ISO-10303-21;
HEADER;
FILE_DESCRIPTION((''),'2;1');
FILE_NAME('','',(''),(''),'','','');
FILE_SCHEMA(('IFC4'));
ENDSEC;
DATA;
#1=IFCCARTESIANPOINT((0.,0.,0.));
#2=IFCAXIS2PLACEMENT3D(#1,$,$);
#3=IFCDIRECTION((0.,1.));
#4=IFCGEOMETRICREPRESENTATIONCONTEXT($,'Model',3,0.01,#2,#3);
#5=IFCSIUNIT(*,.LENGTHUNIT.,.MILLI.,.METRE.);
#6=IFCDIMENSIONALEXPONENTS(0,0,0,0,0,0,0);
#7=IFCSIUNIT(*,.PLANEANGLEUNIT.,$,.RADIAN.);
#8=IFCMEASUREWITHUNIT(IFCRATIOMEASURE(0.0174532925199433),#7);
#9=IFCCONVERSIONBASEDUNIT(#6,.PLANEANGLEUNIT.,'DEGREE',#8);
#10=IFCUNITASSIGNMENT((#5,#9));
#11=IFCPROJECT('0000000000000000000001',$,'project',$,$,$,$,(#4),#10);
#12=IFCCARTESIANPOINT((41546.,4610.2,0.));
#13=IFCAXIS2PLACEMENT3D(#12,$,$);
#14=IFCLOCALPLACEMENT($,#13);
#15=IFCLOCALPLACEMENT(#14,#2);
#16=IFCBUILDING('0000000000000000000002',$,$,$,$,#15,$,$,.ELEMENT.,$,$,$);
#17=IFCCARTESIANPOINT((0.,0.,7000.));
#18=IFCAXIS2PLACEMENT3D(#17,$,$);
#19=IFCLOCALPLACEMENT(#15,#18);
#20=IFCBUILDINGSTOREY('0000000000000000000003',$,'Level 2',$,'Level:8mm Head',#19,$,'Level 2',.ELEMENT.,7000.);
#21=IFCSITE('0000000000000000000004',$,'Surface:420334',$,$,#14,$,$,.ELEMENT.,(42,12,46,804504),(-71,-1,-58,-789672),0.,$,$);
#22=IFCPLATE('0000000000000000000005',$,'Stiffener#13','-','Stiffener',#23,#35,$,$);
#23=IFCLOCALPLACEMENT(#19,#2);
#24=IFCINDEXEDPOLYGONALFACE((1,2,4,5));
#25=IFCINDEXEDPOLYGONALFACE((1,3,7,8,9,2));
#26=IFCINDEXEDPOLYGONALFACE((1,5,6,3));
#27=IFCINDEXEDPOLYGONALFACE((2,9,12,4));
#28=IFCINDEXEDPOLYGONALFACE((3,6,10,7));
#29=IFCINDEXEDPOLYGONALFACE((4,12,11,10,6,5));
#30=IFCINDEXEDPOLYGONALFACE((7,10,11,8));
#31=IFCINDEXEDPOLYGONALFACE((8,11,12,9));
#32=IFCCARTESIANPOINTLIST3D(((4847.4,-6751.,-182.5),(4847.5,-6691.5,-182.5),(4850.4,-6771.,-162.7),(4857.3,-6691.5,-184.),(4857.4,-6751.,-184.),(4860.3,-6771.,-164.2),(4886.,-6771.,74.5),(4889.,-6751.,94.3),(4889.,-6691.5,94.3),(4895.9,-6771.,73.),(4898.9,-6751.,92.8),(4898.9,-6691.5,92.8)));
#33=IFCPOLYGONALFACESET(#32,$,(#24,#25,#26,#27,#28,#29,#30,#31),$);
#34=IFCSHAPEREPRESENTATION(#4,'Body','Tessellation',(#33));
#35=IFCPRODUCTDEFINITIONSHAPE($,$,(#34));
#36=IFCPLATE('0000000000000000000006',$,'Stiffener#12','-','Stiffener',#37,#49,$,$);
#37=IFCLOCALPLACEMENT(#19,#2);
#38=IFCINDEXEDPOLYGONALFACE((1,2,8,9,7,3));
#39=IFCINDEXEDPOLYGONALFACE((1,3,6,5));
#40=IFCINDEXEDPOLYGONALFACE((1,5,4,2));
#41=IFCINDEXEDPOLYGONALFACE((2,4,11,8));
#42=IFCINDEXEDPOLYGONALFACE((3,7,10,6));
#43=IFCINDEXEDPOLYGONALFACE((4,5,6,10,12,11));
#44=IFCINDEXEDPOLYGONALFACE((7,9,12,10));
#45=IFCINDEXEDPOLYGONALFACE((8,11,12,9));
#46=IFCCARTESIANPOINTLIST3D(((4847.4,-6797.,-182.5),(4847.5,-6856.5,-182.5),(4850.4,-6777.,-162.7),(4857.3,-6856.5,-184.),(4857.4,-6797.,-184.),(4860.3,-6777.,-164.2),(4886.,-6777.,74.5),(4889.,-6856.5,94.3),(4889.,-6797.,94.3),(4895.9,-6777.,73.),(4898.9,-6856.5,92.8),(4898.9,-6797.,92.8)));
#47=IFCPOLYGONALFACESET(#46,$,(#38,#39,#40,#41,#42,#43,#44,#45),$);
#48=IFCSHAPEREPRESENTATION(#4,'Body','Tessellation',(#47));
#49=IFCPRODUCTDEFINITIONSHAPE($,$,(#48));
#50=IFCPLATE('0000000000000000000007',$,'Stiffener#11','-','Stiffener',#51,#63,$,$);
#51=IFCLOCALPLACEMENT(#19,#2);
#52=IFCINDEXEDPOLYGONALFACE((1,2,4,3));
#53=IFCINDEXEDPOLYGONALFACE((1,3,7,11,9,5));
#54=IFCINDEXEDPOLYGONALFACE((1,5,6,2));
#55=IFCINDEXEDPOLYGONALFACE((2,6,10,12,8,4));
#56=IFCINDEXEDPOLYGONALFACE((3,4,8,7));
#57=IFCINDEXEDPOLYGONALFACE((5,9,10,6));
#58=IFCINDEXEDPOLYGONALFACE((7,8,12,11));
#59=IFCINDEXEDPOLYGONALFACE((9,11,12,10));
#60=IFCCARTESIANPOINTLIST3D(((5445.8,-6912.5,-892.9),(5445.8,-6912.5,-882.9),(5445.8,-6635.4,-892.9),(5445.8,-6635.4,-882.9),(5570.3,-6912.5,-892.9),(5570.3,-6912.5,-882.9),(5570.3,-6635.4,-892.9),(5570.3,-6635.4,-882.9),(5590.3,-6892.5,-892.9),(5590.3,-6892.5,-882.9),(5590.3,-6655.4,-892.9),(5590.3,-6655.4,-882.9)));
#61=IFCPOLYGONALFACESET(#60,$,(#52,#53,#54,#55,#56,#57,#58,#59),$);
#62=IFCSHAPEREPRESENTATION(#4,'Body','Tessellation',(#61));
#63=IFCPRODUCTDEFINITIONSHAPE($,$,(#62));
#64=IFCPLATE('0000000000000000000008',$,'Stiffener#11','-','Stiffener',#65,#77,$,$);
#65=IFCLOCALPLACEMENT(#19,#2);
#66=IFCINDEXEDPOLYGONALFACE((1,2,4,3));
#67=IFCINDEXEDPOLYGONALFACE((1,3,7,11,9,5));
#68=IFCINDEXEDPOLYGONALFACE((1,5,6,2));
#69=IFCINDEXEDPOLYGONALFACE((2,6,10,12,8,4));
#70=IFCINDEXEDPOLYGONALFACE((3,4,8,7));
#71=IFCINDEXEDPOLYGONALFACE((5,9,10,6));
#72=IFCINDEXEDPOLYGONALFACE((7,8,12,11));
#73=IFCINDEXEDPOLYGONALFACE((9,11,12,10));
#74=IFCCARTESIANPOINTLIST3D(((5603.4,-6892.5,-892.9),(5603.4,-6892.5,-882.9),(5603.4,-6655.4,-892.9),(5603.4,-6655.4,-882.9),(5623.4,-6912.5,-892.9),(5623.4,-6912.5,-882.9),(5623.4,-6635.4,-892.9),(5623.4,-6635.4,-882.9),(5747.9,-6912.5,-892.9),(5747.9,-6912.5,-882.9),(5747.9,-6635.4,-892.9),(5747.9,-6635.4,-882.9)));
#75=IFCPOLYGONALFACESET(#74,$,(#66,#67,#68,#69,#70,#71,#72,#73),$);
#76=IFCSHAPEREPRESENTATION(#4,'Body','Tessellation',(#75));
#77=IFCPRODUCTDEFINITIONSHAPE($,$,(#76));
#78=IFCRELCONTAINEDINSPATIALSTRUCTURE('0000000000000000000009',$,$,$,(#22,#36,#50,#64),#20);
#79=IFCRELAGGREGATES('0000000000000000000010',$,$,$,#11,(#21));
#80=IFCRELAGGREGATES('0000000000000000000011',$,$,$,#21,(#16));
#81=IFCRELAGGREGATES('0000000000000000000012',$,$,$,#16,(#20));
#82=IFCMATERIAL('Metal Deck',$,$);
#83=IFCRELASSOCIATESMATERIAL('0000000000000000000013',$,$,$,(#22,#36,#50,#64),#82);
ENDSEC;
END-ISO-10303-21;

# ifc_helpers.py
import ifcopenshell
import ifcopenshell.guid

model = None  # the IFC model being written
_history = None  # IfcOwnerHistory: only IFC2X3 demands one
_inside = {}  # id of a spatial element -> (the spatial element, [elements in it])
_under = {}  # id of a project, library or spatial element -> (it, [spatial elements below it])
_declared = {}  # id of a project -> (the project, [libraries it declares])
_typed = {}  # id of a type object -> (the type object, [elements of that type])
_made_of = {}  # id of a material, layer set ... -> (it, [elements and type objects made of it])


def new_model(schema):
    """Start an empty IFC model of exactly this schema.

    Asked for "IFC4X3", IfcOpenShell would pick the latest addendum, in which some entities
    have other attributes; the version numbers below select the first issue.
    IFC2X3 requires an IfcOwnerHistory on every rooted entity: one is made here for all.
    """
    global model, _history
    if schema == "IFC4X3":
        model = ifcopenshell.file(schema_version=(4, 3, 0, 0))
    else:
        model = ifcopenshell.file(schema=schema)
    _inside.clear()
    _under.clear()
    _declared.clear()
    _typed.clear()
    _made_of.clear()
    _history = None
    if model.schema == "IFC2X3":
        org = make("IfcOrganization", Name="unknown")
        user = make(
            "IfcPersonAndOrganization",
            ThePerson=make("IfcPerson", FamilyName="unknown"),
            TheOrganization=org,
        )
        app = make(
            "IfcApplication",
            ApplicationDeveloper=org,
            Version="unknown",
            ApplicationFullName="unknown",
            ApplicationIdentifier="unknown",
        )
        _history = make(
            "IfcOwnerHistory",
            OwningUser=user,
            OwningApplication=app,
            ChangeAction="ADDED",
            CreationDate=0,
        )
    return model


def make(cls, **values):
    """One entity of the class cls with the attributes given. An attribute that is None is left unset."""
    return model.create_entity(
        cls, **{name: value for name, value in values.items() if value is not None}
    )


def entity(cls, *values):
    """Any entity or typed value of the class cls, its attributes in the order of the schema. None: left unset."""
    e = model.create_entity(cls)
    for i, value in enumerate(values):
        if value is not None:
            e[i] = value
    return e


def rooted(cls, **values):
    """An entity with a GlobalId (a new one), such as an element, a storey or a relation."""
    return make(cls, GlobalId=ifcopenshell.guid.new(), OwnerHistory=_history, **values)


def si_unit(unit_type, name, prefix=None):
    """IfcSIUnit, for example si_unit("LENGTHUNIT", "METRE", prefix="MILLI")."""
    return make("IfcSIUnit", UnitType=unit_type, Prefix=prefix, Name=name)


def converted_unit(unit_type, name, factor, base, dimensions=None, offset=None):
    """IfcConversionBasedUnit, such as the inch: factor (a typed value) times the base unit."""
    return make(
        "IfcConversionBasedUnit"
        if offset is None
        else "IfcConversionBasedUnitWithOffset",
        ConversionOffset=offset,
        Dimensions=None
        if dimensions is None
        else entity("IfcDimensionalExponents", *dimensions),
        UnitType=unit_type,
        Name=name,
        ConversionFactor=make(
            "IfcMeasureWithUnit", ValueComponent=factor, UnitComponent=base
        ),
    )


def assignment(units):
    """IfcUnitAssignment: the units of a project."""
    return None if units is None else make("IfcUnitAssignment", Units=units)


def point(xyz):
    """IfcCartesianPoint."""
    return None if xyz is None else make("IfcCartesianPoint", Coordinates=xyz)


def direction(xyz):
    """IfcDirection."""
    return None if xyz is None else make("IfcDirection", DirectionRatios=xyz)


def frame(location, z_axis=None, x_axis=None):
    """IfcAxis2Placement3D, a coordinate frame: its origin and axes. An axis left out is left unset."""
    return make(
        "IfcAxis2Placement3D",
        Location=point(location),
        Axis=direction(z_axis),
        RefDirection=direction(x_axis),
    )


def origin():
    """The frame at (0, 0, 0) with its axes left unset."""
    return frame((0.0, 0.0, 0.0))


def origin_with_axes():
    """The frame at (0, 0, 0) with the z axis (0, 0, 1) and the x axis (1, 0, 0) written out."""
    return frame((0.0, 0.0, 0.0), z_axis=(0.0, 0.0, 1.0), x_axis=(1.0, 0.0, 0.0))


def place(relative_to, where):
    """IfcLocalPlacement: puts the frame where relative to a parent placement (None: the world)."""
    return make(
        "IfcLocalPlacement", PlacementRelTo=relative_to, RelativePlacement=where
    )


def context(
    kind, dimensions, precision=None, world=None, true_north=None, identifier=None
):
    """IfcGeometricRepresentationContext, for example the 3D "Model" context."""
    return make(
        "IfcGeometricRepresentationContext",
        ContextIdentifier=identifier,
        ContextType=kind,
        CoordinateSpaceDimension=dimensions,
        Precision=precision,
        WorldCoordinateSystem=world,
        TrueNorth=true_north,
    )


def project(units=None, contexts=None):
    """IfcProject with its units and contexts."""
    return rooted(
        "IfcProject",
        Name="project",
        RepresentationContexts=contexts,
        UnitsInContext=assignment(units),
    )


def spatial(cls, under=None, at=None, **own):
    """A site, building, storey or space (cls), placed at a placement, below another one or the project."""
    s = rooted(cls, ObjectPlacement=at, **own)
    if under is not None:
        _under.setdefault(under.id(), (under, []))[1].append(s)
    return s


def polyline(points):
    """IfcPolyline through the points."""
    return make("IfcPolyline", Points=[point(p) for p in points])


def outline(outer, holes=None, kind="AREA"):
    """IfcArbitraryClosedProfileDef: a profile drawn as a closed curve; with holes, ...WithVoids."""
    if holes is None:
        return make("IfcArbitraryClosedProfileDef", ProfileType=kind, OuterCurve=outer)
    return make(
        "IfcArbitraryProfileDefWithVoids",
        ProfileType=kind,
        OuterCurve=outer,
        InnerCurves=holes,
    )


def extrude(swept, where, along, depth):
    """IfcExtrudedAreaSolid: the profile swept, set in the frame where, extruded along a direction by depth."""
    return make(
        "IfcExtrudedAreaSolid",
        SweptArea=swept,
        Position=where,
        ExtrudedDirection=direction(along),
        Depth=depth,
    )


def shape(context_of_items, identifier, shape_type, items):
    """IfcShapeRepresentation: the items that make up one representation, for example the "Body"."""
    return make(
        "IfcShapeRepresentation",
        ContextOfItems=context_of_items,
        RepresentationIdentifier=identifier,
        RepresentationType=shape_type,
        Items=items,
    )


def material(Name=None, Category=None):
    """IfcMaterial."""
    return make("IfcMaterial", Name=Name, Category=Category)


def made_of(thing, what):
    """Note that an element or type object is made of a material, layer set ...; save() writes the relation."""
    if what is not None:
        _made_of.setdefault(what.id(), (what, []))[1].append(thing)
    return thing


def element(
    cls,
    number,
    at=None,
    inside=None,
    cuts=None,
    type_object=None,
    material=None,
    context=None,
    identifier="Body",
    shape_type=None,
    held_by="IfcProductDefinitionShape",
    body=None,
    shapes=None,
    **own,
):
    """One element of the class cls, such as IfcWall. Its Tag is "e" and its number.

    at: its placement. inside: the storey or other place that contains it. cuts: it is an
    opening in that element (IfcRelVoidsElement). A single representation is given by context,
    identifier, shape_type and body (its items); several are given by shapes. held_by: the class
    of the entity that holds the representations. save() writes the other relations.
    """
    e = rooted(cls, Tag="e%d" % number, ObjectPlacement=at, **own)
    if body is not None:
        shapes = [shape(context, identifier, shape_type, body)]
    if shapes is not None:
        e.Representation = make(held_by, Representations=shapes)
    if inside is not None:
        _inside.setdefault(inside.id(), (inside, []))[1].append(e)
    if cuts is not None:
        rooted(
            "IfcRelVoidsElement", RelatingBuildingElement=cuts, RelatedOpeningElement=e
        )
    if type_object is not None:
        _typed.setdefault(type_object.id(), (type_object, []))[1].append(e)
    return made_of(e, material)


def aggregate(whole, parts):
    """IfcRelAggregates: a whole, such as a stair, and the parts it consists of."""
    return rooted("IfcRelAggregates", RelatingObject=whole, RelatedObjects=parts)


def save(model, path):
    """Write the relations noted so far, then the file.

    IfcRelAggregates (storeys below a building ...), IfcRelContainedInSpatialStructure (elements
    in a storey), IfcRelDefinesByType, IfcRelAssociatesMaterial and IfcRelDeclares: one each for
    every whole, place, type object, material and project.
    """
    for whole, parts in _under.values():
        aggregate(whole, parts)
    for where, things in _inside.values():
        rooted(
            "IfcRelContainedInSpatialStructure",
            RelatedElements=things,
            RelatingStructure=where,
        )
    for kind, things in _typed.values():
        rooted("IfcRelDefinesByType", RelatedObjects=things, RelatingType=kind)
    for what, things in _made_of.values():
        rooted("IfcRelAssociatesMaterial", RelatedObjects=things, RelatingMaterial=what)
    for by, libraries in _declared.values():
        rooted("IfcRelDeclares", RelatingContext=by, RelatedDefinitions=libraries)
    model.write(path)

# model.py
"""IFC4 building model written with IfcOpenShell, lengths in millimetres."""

from ifc_helpers import new_model, entity, si_unit, converted_unit, direction, frame, origin, origin_with_axes, place, context, project, spatial, polyline, outline, extrude, material, element, save


model = new_model("IFC4")

# Units and contexts
model_context = context("Model", 3, precision=0.01, world=origin(), true_north=direction((0.0, 1.0)))
ifc_project = project(units=[si_unit("LENGTHUNIT", "METRE", prefix="MILLI"), converted_unit("PLANEANGLEUNIT", "DEGREE", entity("IfcRatioMeasure", 0.0174532925199433), si_unit("PLANEANGLEUNIT", "RADIAN"), dimensions=[0, 0, 0, 0, 0, 0, 0])], contexts=[model_context])

# Site, building, storey
site_placement = place(None, frame((41546.0, 4610.2, 0.0)))
site = spatial("IfcSite", under=ifc_project, at=site_placement, Name="Surface:420334", CompositionType="ELEMENT", RefLatitude=(42, 12, 46, 804504), RefLongitude=(-71, -1, -58, -789672), RefElevation=0.0)
building_placement = place(site_placement, origin())
building = spatial("IfcBuilding", under=site, at=building_placement, CompositionType="ELEMENT")
storey_placement = place(building_placement, frame((0.0, 0.0, 7000.0)))
storey = spatial("IfcBuildingStorey", under=building, at=storey_placement, Name="Level 2", ObjectType="Level:8mm Head", LongName="Level 2", CompositionType="ELEMENT", Elevation=7000.0)

# Plates, openings
ifc_material = material(Name="Metal Deck")
plate_1_placement = place(storey_placement, frame((4857.3, -6691.5, -184.0), z_axis=(-0.988936, 0.0, 0.14834), x_axis=(0.0, -1.0, 0.0)))
plate_1 = element("IfcPlate", 1, at=plate_1_placement, inside=storey, material=ifc_material, Name="Stiffener#13", Description="-", ObjectType="Stiffener", context=model_context, shape_type="SweptSolid", body=[
    extrude(outline(polyline([(0.0, 0.0), (79.5, 0.0), (79.5, 279.8), (0.0, 279.8), (0.0, 0.0)])), origin_with_axes(), (0.0, 0.0, 1.0), 10.0),
])
opening_1_placement = place(plate_1_placement, frame((0.0, 0.0, 0.0), z_axis=(0.0, 0.0, 1.0), x_axis=(1.0, 0.0, 0.0)))
element("IfcOpeningElement", 2, at=opening_1_placement, cuts=plate_1, ObjectType="Opening", context=model_context, shape_type="SweptSolid", body=[
    extrude(outline(polyline([(79.5, 279.8), (59.5, 279.8), (79.5, 259.8), (79.5, 279.8)])), origin(), (0.0, 0.0, 1.0), 10.0),
])
opening_2_placement = place(plate_1_placement, frame((0.0, 0.0, 0.0), z_axis=(0.0, 0.0, 1.0), x_axis=(1.0, 0.0, 0.0)))
element("IfcOpeningElement", 3, at=opening_2_placement, cuts=plate_1, ObjectType="Opening", context=model_context, shape_type="SweptSolid", body=[
    extrude(outline(polyline([(79.5, 0.0), (79.5, 20.0), (59.5, 0.0), (79.5, 0.0)])), origin(), (0.0, 0.0, 1.0), 10.0),
])
plate_2_placement = place(storey_placement, frame((4857.3, -6777.0, -184.0), z_axis=(-0.988936, 0.0, 0.14834), x_axis=(0.0, -1.0, 0.0)))
plate_2 = element("IfcPlate", 4, at=plate_2_placement, inside=storey, material=ifc_material, Name="Stiffener#12", Description="-", ObjectType="Stiffener", context=model_context, shape_type="SweptSolid", body=[
    extrude(outline(polyline([(0.0, 0.0), (79.5, 0.0), (79.5, 279.8), (0.0, 279.8), (0.0, 0.0)])), origin_with_axes(), (0.0, 0.0, 1.0), 10.0),
])
opening_3_placement = place(plate_2_placement, frame((0.0, 0.0, 0.0), z_axis=(0.0, 0.0, 1.0), x_axis=(1.0, 0.0, 0.0)))
element("IfcOpeningElement", 5, at=opening_3_placement, cuts=plate_2, ObjectType="Opening", context=model_context, shape_type="SweptSolid", body=[
    extrude(outline(polyline([(0.0, 279.8), (0.0, 259.8), (20.0, 279.8), (0.0, 279.8)])), origin(), (0.0, 0.0, 1.0), 10.0),
])
opening_4_placement = place(plate_2_placement, frame((0.0, 0.0, 0.0), z_axis=(0.0, 0.0, 1.0), x_axis=(1.0, 0.0, 0.0)))
element("IfcOpeningElement", 6, at=opening_4_placement, cuts=plate_2, ObjectType="Opening", context=model_context, shape_type="SweptSolid", body=[
    extrude(outline(polyline([(0.0, 0.0), (20.0, 0.0), (0.0, 20.0), (0.0, 0.0)])), origin(), (0.0, 0.0, 1.0), 10.0),
])
plate_3_placement = place(storey_placement, frame((5445.8, -6912.5, -882.9), z_axis=(0.0, 0.0, -1.0), x_axis=(0.0, 1.0, 0.0)))
plate_3 = element("IfcPlate", 7, at=plate_3_placement, inside=storey, material=ifc_material, Name="Stiffener#11", Description="-", ObjectType="Stiffener", context=model_context, shape_type="SweptSolid", body=[
    extrude(outline(polyline([(0.0, 0.0), (277.1, 0.0), (277.1, 144.5), (0.0, 144.5), (0.0, 0.0)])), origin_with_axes(), (0.0, 0.0, 1.0), 10.0),
])
opening_5_placement = place(plate_3_placement, frame((0.0, 0.0, 0.0), z_axis=(0.0, 0.0, 1.0), x_axis=(1.0, 0.0, 0.0)))
element("IfcOpeningElement", 8, at=opening_5_placement, cuts=plate_3, ObjectType="Opening", context=model_context, shape_type="SweptSolid", body=[
    extrude(outline(polyline([(277.1, 144.5), (257.1, 144.5), (277.1, 124.5), (277.1, 144.5)])), origin(), (0.0, 0.0, 1.0), 10.0),
])
opening_6_placement = place(plate_3_placement, frame((0.0, 0.0, 0.0), z_axis=(0.0, 0.0, 1.0), x_axis=(1.0, 0.0, 0.0)))
element("IfcOpeningElement", 9, at=opening_6_placement, cuts=plate_3, ObjectType="Opening", context=model_context, shape_type="SweptSolid", body=[
    extrude(outline(polyline([(0.0, 144.5), (0.0, 124.5), (20.0, 144.5), (0.0, 144.5)])), origin(), (0.0, 0.0, 1.0), 10.0),
])
plate_4_placement = place(storey_placement, frame((5603.4, -6912.5, -882.9), z_axis=(0.0, 0.0, -1.0), x_axis=(0.0, 1.0, 0.0)))
plate_4 = element("IfcPlate", 10, at=plate_4_placement, inside=storey, material=ifc_material, Name="Stiffener#11", Description="-", ObjectType="Stiffener", context=model_context, shape_type="SweptSolid", body=[
    extrude(outline(polyline([(0.0, 0.0), (277.1, 0.0), (277.1, 144.5), (0.0, 144.5), (0.0, 0.0)])), origin_with_axes(), (0.0, 0.0, 1.0), 10.0),
])
opening_7_placement = place(plate_4_placement, frame((0.0, 0.0, 0.0), z_axis=(0.0, 0.0, 1.0), x_axis=(1.0, 0.0, 0.0)))
element("IfcOpeningElement", 11, at=opening_7_placement, cuts=plate_4, ObjectType="Opening", context=model_context, shape_type="SweptSolid", body=[
    extrude(outline(polyline([(277.1, 0.0), (277.1, 20.0), (257.1, 0.0), (277.1, 0.0)])), origin(), (0.0, 0.0, 1.0), 10.0),
])
opening_8_placement = place(plate_4_placement, frame((0.0, 0.0, 0.0), z_axis=(0.0, 0.0, 1.0), x_axis=(1.0, 0.0, 0.0)))
element("IfcOpeningElement", 12, at=opening_8_placement, cuts=plate_4, ObjectType="Opening", context=model_context, shape_type="SweptSolid", body=[
    extrude(outline(polyline([(0.0, 0.0), (20.0, 0.0), (0.0, 20.0), (0.0, 0.0)])), origin(), (0.0, 0.0, 1.0), 10.0),
])

save(model, "model.ifc")
